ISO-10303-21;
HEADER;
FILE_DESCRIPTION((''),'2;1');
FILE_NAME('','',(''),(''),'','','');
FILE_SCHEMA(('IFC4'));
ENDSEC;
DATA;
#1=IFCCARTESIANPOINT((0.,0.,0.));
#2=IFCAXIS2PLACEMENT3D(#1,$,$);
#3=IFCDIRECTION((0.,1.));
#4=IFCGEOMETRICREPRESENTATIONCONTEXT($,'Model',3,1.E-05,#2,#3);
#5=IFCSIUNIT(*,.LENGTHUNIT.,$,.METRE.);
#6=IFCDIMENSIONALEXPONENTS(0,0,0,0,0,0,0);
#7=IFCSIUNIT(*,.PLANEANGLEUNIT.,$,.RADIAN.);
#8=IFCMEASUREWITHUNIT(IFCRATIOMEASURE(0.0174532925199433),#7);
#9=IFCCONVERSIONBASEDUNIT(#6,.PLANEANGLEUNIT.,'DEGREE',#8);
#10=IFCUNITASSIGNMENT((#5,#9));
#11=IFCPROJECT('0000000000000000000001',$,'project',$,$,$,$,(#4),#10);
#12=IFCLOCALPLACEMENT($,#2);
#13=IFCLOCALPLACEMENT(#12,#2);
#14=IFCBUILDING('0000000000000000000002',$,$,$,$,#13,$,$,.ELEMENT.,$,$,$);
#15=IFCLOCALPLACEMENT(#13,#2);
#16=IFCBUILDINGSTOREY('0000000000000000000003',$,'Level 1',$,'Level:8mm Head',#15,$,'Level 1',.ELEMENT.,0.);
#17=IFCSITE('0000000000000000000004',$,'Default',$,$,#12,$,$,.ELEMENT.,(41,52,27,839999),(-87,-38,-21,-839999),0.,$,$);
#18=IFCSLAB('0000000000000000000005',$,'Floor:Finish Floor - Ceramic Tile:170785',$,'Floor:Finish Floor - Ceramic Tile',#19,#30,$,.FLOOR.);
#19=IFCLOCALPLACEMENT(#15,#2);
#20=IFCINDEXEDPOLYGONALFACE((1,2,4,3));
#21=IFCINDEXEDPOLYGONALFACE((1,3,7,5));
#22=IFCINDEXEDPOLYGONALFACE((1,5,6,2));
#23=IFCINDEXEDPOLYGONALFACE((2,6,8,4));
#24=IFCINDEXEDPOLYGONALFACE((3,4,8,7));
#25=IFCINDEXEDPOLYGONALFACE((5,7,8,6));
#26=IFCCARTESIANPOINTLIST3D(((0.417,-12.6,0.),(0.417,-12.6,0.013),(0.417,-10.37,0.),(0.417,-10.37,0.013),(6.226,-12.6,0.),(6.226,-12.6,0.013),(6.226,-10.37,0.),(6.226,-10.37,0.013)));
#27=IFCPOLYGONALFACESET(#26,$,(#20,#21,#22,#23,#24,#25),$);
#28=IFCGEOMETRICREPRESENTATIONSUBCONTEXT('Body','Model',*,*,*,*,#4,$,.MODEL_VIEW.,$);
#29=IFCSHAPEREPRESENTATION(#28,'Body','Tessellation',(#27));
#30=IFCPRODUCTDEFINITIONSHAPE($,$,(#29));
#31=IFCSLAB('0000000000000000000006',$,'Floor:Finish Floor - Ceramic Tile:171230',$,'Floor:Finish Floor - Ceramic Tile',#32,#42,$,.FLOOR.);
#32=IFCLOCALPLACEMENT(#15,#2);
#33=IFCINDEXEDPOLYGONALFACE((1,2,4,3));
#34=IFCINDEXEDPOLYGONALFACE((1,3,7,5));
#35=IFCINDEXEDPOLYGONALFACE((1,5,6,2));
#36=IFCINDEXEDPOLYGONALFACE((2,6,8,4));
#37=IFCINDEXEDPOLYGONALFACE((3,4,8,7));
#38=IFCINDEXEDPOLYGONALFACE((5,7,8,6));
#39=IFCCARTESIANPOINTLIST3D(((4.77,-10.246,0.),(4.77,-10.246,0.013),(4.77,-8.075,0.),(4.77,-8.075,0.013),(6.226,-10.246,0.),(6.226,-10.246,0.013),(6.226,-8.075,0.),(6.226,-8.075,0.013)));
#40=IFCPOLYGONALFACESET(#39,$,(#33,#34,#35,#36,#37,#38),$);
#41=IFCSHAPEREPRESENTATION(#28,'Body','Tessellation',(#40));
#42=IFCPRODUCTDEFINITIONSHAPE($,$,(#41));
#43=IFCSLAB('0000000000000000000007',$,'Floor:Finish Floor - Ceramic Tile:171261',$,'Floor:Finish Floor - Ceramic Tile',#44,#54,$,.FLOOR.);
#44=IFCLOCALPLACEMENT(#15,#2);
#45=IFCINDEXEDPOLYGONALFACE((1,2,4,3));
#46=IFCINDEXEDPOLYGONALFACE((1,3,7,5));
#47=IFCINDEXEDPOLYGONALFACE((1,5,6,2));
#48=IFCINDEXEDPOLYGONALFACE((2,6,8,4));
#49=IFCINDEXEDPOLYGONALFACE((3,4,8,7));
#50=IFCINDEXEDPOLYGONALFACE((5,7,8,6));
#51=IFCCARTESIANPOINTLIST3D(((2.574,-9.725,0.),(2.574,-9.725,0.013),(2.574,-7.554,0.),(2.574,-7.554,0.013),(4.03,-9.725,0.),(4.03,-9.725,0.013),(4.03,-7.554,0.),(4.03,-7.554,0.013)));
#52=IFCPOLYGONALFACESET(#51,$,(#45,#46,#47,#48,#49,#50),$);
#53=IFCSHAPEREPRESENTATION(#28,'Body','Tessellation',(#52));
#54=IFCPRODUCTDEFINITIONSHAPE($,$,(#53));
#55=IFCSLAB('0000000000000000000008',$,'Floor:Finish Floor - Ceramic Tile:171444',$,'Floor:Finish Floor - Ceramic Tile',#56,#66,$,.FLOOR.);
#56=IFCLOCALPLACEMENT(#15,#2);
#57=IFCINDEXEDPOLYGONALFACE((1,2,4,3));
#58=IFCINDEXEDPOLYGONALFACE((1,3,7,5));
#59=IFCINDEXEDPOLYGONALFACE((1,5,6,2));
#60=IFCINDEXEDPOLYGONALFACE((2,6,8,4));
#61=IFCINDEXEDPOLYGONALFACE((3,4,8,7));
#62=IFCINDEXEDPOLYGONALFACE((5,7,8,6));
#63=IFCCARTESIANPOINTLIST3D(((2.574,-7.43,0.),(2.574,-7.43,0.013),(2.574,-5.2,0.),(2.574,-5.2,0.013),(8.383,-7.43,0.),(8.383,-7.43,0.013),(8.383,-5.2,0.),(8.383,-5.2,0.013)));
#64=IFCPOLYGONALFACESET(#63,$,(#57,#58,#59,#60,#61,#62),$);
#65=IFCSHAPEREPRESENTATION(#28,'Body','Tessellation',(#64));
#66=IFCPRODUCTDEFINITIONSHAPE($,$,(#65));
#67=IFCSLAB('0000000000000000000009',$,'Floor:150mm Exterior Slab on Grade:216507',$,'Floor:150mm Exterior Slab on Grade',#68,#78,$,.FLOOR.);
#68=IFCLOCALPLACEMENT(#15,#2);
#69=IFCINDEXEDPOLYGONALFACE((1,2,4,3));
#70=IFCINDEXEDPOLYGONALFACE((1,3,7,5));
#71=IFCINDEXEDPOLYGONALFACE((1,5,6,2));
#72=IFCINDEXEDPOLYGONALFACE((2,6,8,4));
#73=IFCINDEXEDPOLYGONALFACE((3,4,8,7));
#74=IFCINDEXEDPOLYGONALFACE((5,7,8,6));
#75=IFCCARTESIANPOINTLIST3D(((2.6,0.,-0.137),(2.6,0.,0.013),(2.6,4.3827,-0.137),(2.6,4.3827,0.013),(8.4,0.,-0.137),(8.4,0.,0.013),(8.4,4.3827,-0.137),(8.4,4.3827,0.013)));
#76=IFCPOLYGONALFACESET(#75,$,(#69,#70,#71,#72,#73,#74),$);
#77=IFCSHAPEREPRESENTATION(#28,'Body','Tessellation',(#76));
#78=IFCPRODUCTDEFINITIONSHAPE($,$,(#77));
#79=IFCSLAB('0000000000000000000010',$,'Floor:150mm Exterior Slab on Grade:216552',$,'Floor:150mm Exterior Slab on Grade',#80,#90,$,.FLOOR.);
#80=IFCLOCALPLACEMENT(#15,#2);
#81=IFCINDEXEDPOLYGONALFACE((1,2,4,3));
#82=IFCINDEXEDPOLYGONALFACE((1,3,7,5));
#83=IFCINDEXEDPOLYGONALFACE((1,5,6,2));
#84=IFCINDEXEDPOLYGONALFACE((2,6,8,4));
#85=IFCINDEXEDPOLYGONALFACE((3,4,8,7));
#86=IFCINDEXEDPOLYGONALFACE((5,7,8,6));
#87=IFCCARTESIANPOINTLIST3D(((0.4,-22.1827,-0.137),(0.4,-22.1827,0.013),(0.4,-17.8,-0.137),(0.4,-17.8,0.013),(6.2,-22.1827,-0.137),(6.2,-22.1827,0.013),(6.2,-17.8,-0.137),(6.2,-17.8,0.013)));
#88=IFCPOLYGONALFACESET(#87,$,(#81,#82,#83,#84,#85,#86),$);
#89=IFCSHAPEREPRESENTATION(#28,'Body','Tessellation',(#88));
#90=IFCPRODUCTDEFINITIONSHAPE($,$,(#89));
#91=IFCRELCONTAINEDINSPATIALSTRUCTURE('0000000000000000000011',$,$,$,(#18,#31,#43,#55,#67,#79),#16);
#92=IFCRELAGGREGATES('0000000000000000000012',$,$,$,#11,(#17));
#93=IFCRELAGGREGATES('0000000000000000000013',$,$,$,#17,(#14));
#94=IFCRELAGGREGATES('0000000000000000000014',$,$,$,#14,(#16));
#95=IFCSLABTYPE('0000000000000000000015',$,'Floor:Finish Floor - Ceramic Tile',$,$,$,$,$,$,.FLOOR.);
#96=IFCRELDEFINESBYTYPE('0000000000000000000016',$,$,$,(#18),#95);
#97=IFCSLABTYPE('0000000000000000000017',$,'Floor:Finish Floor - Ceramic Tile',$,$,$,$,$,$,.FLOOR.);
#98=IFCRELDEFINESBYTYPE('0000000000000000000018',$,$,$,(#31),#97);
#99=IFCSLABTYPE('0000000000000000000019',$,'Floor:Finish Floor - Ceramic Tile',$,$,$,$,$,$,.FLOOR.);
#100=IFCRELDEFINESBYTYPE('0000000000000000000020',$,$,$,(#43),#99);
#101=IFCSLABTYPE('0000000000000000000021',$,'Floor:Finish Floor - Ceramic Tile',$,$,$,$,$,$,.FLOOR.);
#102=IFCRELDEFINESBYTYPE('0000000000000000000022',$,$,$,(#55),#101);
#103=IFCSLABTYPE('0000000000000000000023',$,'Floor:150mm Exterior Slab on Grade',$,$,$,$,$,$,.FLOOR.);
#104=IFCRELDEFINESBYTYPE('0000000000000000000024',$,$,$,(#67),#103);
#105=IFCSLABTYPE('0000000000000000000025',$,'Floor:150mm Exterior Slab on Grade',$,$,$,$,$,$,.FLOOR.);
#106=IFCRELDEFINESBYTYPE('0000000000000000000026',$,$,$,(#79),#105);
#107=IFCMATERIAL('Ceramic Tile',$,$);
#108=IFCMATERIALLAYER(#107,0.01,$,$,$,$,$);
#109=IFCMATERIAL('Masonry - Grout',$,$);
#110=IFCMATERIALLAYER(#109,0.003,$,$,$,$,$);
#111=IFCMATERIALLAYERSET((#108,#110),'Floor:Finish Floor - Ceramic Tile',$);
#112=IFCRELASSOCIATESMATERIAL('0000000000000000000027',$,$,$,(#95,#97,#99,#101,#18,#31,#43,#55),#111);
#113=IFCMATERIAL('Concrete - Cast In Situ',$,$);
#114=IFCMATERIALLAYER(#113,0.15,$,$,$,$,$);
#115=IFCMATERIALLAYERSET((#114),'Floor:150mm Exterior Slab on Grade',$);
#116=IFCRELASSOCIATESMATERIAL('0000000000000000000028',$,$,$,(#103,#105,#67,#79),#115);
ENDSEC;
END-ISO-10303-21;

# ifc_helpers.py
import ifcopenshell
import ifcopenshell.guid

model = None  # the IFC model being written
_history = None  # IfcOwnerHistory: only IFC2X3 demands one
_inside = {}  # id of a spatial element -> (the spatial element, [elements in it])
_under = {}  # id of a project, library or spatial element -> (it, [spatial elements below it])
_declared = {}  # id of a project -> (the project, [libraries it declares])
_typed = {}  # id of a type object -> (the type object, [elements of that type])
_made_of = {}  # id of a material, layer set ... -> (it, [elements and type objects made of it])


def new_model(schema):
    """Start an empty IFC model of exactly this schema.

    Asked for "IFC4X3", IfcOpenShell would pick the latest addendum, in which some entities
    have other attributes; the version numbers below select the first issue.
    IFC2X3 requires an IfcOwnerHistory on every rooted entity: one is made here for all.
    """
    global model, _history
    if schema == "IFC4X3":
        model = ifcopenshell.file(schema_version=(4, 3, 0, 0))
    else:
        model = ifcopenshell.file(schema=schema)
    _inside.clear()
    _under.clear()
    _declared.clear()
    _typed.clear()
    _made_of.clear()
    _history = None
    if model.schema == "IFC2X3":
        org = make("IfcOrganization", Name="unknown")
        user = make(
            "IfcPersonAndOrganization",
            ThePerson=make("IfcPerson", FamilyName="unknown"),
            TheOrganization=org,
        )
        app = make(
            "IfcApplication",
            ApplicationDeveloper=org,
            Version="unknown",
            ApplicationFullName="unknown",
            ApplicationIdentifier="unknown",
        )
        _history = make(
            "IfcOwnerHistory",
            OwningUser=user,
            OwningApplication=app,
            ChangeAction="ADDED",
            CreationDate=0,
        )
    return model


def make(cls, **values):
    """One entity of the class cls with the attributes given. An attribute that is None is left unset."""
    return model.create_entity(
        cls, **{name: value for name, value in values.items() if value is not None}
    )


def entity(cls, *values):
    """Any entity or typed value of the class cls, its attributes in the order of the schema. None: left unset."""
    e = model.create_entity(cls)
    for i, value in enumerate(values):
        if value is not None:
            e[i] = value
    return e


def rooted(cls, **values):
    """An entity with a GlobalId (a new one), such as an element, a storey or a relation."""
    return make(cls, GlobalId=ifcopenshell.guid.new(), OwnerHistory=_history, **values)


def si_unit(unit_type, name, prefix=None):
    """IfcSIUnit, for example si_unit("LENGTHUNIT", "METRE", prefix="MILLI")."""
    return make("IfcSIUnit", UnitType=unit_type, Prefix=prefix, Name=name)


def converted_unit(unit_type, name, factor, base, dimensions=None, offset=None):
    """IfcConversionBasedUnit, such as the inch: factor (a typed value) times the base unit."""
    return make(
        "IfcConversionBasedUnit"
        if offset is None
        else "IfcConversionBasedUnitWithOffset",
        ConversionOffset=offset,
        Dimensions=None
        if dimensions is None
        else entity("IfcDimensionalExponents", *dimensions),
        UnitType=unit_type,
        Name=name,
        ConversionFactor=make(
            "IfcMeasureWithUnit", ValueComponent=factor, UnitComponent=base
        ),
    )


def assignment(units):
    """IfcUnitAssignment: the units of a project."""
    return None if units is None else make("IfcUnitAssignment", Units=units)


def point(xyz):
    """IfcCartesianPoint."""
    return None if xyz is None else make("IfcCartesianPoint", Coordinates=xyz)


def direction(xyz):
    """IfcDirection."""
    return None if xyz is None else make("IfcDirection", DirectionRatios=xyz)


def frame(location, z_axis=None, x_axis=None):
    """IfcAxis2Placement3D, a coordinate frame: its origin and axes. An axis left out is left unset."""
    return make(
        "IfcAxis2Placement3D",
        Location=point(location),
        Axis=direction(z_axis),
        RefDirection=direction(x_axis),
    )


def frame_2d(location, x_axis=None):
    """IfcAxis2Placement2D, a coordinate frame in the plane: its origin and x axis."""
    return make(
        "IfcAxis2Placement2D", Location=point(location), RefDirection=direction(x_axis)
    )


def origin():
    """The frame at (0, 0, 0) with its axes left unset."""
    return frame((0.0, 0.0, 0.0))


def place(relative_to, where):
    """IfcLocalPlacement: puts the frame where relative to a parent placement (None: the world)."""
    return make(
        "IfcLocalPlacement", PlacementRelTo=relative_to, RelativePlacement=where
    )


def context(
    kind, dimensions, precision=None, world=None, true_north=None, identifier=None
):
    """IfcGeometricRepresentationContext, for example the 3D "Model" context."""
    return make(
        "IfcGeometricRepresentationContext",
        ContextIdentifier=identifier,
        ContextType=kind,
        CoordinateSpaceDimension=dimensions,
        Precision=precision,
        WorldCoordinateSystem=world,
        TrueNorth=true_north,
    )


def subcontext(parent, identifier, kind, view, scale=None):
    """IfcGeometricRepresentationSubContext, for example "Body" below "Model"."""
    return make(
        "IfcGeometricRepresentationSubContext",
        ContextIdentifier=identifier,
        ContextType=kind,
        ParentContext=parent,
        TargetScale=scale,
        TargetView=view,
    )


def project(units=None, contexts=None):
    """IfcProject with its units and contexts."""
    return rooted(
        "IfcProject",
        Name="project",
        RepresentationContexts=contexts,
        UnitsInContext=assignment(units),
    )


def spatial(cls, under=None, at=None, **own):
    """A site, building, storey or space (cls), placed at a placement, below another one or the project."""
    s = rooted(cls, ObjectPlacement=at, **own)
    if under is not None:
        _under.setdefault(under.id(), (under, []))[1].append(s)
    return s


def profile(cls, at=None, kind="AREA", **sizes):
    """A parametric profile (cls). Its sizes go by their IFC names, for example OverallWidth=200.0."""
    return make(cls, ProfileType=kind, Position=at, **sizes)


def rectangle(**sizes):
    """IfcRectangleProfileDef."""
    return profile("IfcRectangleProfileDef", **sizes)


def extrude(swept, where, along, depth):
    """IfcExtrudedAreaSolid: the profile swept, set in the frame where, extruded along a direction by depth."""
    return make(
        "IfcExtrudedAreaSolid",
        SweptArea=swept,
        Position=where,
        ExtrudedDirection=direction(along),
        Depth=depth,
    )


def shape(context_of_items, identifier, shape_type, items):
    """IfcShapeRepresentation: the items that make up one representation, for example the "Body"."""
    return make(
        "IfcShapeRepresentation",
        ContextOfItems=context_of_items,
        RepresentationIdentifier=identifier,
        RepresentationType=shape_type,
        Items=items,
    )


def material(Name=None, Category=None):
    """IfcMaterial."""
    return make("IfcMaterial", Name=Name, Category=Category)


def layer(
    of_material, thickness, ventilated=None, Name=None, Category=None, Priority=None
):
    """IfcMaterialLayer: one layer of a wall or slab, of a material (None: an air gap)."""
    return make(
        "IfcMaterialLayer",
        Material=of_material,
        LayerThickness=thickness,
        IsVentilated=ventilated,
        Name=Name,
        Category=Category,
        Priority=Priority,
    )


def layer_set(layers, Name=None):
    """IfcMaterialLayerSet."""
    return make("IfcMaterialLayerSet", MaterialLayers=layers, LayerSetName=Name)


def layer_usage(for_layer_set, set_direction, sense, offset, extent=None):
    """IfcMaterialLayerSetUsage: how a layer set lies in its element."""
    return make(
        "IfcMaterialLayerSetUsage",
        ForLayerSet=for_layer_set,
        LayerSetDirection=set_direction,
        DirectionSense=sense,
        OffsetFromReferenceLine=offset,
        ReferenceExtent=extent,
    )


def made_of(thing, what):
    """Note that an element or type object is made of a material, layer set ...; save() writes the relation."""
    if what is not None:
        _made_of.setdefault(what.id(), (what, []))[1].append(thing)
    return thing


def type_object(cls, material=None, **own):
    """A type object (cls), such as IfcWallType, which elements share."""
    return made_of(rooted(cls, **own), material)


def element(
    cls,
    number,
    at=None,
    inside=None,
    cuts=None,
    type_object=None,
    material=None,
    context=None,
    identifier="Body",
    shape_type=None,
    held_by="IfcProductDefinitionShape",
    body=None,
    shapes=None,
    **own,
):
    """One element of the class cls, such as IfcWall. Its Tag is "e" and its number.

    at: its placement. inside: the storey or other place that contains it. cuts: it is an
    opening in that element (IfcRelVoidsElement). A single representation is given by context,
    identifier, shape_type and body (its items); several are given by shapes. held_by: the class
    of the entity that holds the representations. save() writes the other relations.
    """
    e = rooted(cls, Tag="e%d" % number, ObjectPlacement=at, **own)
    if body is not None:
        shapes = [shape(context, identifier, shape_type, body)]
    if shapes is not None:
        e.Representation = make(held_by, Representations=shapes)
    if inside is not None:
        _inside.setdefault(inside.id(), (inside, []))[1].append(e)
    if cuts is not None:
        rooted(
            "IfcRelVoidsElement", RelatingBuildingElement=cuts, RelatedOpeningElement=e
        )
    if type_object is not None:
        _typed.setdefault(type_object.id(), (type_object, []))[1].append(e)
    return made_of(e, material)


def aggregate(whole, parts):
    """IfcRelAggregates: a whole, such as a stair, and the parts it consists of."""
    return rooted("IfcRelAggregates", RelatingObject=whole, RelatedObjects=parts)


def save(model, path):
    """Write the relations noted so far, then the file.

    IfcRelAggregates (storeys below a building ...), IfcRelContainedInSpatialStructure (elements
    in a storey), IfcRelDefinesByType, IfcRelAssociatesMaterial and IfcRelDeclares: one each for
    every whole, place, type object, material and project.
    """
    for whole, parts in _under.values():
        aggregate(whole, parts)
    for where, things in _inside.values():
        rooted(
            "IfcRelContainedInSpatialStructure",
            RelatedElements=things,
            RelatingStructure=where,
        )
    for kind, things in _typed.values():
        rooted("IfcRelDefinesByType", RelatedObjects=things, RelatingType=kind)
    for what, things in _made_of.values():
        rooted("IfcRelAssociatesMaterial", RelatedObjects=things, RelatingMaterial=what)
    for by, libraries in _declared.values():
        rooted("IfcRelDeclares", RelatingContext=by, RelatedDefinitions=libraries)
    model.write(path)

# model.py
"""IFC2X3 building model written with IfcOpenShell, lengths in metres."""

from ifc_helpers import new_model, entity, si_unit, converted_unit, direction, frame, frame_2d, origin, place, context, subcontext, project, spatial, rectangle, extrude, material, layer, layer_set, layer_usage, type_object, element, save


model = new_model("IFC2X3")

# Units and contexts
model_context = context("Model", 3, precision=1e-05, world=origin(), true_north=direction((0.0, 1.0)))
body_context = subcontext(model_context, "Body", "Model", "MODEL_VIEW")
ifc_project = project(units=[si_unit("LENGTHUNIT", "METRE"), converted_unit("PLANEANGLEUNIT", "DEGREE", entity("IfcRatioMeasure", 0.0174532925199433), si_unit("PLANEANGLEUNIT", "RADIAN"), dimensions=[0, 0, 0, 0, 0, 0, 0])], contexts=[model_context])

# Site, building, storey
site_placement = place(None, origin())
site = spatial("IfcSite", under=ifc_project, at=site_placement, Name="Default", CompositionType="ELEMENT", RefLatitude=(41, 52, 27, 839999), RefLongitude=(-87, -38, -21, -839999), RefElevation=0.0)
building_placement = place(site_placement, origin())
building = spatial("IfcBuilding", under=site, at=building_placement, CompositionType="ELEMENT")
storey_placement = place(building_placement, origin())
storey = spatial("IfcBuildingStorey", under=building, at=storey_placement, Name="Level 1", ObjectType="Level:8mm Head", LongName="Level 1", CompositionType="ELEMENT", Elevation=0.0)

# Slabs
ifc_material_1 = material(Name="Ceramic Tile")
ifc_layer_1 = layer(ifc_material_1, 0.01)
ifc_material_2 = material(Name="Masonry - Grout")
ifc_layer_2 = layer(ifc_material_2, 0.003)
ifc_layer_set_1 = layer_set([ifc_layer_1, ifc_layer_2], Name="Floor:Finish Floor - Ceramic Tile")
ifc_layer_usage_1 = layer_usage(ifc_layer_set_1, "AXIS3", "POSITIVE", 0.0)
slab_type_1 = type_object("IfcSlabType", Name="Floor:Finish Floor - Ceramic Tile", PredefinedType="FLOOR", material=ifc_layer_set_1)
slab_1_placement = place(storey_placement, origin())
element("IfcSlab", 1, at=slab_1_placement, inside=storey, type_object=slab_type_1, material=ifc_layer_usage_1, Name="Floor:Finish Floor - Ceramic Tile:170785", ObjectType="Floor:Finish Floor - Ceramic Tile", PredefinedType="FLOOR", context=body_context, shape_type="SweptSolid", body=[
    extrude(rectangle(XDim=2.23, YDim=5.809, at=frame_2d((0.0, 0.0), x_axis=(1.0, 0.0))), frame((3.3215, -11.485, 0.013), z_axis=(0.0, 0.0, -1.0), x_axis=(0.0, 1.0, 0.0)), (0.0, 0.0, 1.0), 0.013),
])
ifc_layer_usage_2 = layer_usage(ifc_layer_set_1, "AXIS3", "POSITIVE", 0.0)
slab_type_2 = type_object("IfcSlabType", Name="Floor:Finish Floor - Ceramic Tile", PredefinedType="FLOOR", material=ifc_layer_set_1)
slab_2_placement = place(storey_placement, origin())
element("IfcSlab", 2, at=slab_2_placement, inside=storey, type_object=slab_type_2, material=ifc_layer_usage_2, Name="Floor:Finish Floor - Ceramic Tile:171230", ObjectType="Floor:Finish Floor - Ceramic Tile", PredefinedType="FLOOR", context=body_context, shape_type="SweptSolid", body=[
    extrude(rectangle(XDim=2.171, YDim=1.456, at=frame_2d((0.0, 0.0), x_axis=(1.0, 0.0))), frame((5.498, -9.1605, 0.013), z_axis=(0.0, 0.0, -1.0), x_axis=(0.0, 1.0, 0.0)), (0.0, 0.0, 1.0), 0.013),
])
ifc_layer_usage_3 = layer_usage(ifc_layer_set_1, "AXIS3", "POSITIVE", 0.0)
slab_type_3 = type_object("IfcSlabType", Name="Floor:Finish Floor - Ceramic Tile", PredefinedType="FLOOR", material=ifc_layer_set_1)
slab_3_placement = place(storey_placement, origin())
element("IfcSlab", 3, at=slab_3_placement, inside=storey, type_object=slab_type_3, material=ifc_layer_usage_3, Name="Floor:Finish Floor - Ceramic Tile:171261", ObjectType="Floor:Finish Floor - Ceramic Tile", PredefinedType="FLOOR", context=body_context, shape_type="SweptSolid", body=[
    extrude(rectangle(XDim=2.171, YDim=1.456, at=frame_2d((0.0, 0.0), x_axis=(1.0, 0.0))), frame((3.302, -8.6395, 0.013), z_axis=(0.0, 0.0, -1.0), x_axis=(0.0, 1.0, 0.0)), (0.0, 0.0, 1.0), 0.013),
])
ifc_layer_usage_4 = layer_usage(ifc_layer_set_1, "AXIS3", "POSITIVE", 0.0)
slab_type_4 = type_object("IfcSlabType", Name="Floor:Finish Floor - Ceramic Tile", PredefinedType="FLOOR", material=ifc_layer_set_1)
slab_4_placement = place(storey_placement, origin())
element("IfcSlab", 4, at=slab_4_placement, inside=storey, type_object=slab_type_4, material=ifc_layer_usage_4, Name="Floor:Finish Floor - Ceramic Tile:171444", ObjectType="Floor:Finish Floor - Ceramic Tile", PredefinedType="FLOOR", context=body_context, shape_type="SweptSolid", body=[
    extrude(rectangle(XDim=2.23, YDim=5.809, at=frame_2d((0.0, 0.0), x_axis=(1.0, 0.0))), frame((5.4785, -6.315, 0.013), z_axis=(0.0, 0.0, -1.0), x_axis=(0.0, 1.0, 0.0)), (0.0, 0.0, 1.0), 0.013),
])
ifc_material_3 = material(Name="Concrete - Cast In Situ")
ifc_layer_3 = layer(ifc_material_3, 0.15)
ifc_layer_set_2 = layer_set([ifc_layer_3], Name="Floor:150mm Exterior Slab on Grade")
ifc_layer_usage_5 = layer_usage(ifc_layer_set_2, "AXIS3", "POSITIVE", 0.0)
slab_type_5 = type_object("IfcSlabType", Name="Floor:150mm Exterior Slab on Grade", PredefinedType="FLOOR", material=ifc_layer_set_2)
slab_5_placement = place(storey_placement, origin())
element("IfcSlab", 5, at=slab_5_placement, inside=storey, type_object=slab_type_5, material=ifc_layer_usage_5, Name="Floor:150mm Exterior Slab on Grade:216507", ObjectType="Floor:150mm Exterior Slab on Grade", PredefinedType="FLOOR", context=body_context, shape_type="SweptSolid", body=[
    extrude(rectangle(XDim=4.3827, YDim=5.8, at=frame_2d((0.0, 0.0), x_axis=(1.0, 0.0))), frame((5.5, 2.1914, 0.013), z_axis=(0.0, 0.0, -1.0), x_axis=(0.0, 1.0, 0.0)), (0.0, 0.0, 1.0), 0.15),
])
ifc_layer_usage_6 = layer_usage(ifc_layer_set_2, "AXIS3", "POSITIVE", 0.0)
slab_type_6 = type_object("IfcSlabType", Name="Floor:150mm Exterior Slab on Grade", PredefinedType="FLOOR", material=ifc_layer_set_2)
slab_6_placement = place(storey_placement, origin())
element("IfcSlab", 6, at=slab_6_placement, inside=storey, type_object=slab_type_6, material=ifc_layer_usage_6, Name="Floor:150mm Exterior Slab on Grade:216552", ObjectType="Floor:150mm Exterior Slab on Grade", PredefinedType="FLOOR", context=body_context, shape_type="SweptSolid", body=[
    extrude(rectangle(XDim=4.3827, YDim=5.8, at=frame_2d((0.0, 0.0), x_axis=(1.0, 0.0))), frame((3.3, -19.9914, 0.013), z_axis=(0.0, 0.0, -1.0), x_axis=(0.0, 1.0, 0.0)), (0.0, 0.0, 1.0), 0.15),
])

save(model, "model.ifc")
